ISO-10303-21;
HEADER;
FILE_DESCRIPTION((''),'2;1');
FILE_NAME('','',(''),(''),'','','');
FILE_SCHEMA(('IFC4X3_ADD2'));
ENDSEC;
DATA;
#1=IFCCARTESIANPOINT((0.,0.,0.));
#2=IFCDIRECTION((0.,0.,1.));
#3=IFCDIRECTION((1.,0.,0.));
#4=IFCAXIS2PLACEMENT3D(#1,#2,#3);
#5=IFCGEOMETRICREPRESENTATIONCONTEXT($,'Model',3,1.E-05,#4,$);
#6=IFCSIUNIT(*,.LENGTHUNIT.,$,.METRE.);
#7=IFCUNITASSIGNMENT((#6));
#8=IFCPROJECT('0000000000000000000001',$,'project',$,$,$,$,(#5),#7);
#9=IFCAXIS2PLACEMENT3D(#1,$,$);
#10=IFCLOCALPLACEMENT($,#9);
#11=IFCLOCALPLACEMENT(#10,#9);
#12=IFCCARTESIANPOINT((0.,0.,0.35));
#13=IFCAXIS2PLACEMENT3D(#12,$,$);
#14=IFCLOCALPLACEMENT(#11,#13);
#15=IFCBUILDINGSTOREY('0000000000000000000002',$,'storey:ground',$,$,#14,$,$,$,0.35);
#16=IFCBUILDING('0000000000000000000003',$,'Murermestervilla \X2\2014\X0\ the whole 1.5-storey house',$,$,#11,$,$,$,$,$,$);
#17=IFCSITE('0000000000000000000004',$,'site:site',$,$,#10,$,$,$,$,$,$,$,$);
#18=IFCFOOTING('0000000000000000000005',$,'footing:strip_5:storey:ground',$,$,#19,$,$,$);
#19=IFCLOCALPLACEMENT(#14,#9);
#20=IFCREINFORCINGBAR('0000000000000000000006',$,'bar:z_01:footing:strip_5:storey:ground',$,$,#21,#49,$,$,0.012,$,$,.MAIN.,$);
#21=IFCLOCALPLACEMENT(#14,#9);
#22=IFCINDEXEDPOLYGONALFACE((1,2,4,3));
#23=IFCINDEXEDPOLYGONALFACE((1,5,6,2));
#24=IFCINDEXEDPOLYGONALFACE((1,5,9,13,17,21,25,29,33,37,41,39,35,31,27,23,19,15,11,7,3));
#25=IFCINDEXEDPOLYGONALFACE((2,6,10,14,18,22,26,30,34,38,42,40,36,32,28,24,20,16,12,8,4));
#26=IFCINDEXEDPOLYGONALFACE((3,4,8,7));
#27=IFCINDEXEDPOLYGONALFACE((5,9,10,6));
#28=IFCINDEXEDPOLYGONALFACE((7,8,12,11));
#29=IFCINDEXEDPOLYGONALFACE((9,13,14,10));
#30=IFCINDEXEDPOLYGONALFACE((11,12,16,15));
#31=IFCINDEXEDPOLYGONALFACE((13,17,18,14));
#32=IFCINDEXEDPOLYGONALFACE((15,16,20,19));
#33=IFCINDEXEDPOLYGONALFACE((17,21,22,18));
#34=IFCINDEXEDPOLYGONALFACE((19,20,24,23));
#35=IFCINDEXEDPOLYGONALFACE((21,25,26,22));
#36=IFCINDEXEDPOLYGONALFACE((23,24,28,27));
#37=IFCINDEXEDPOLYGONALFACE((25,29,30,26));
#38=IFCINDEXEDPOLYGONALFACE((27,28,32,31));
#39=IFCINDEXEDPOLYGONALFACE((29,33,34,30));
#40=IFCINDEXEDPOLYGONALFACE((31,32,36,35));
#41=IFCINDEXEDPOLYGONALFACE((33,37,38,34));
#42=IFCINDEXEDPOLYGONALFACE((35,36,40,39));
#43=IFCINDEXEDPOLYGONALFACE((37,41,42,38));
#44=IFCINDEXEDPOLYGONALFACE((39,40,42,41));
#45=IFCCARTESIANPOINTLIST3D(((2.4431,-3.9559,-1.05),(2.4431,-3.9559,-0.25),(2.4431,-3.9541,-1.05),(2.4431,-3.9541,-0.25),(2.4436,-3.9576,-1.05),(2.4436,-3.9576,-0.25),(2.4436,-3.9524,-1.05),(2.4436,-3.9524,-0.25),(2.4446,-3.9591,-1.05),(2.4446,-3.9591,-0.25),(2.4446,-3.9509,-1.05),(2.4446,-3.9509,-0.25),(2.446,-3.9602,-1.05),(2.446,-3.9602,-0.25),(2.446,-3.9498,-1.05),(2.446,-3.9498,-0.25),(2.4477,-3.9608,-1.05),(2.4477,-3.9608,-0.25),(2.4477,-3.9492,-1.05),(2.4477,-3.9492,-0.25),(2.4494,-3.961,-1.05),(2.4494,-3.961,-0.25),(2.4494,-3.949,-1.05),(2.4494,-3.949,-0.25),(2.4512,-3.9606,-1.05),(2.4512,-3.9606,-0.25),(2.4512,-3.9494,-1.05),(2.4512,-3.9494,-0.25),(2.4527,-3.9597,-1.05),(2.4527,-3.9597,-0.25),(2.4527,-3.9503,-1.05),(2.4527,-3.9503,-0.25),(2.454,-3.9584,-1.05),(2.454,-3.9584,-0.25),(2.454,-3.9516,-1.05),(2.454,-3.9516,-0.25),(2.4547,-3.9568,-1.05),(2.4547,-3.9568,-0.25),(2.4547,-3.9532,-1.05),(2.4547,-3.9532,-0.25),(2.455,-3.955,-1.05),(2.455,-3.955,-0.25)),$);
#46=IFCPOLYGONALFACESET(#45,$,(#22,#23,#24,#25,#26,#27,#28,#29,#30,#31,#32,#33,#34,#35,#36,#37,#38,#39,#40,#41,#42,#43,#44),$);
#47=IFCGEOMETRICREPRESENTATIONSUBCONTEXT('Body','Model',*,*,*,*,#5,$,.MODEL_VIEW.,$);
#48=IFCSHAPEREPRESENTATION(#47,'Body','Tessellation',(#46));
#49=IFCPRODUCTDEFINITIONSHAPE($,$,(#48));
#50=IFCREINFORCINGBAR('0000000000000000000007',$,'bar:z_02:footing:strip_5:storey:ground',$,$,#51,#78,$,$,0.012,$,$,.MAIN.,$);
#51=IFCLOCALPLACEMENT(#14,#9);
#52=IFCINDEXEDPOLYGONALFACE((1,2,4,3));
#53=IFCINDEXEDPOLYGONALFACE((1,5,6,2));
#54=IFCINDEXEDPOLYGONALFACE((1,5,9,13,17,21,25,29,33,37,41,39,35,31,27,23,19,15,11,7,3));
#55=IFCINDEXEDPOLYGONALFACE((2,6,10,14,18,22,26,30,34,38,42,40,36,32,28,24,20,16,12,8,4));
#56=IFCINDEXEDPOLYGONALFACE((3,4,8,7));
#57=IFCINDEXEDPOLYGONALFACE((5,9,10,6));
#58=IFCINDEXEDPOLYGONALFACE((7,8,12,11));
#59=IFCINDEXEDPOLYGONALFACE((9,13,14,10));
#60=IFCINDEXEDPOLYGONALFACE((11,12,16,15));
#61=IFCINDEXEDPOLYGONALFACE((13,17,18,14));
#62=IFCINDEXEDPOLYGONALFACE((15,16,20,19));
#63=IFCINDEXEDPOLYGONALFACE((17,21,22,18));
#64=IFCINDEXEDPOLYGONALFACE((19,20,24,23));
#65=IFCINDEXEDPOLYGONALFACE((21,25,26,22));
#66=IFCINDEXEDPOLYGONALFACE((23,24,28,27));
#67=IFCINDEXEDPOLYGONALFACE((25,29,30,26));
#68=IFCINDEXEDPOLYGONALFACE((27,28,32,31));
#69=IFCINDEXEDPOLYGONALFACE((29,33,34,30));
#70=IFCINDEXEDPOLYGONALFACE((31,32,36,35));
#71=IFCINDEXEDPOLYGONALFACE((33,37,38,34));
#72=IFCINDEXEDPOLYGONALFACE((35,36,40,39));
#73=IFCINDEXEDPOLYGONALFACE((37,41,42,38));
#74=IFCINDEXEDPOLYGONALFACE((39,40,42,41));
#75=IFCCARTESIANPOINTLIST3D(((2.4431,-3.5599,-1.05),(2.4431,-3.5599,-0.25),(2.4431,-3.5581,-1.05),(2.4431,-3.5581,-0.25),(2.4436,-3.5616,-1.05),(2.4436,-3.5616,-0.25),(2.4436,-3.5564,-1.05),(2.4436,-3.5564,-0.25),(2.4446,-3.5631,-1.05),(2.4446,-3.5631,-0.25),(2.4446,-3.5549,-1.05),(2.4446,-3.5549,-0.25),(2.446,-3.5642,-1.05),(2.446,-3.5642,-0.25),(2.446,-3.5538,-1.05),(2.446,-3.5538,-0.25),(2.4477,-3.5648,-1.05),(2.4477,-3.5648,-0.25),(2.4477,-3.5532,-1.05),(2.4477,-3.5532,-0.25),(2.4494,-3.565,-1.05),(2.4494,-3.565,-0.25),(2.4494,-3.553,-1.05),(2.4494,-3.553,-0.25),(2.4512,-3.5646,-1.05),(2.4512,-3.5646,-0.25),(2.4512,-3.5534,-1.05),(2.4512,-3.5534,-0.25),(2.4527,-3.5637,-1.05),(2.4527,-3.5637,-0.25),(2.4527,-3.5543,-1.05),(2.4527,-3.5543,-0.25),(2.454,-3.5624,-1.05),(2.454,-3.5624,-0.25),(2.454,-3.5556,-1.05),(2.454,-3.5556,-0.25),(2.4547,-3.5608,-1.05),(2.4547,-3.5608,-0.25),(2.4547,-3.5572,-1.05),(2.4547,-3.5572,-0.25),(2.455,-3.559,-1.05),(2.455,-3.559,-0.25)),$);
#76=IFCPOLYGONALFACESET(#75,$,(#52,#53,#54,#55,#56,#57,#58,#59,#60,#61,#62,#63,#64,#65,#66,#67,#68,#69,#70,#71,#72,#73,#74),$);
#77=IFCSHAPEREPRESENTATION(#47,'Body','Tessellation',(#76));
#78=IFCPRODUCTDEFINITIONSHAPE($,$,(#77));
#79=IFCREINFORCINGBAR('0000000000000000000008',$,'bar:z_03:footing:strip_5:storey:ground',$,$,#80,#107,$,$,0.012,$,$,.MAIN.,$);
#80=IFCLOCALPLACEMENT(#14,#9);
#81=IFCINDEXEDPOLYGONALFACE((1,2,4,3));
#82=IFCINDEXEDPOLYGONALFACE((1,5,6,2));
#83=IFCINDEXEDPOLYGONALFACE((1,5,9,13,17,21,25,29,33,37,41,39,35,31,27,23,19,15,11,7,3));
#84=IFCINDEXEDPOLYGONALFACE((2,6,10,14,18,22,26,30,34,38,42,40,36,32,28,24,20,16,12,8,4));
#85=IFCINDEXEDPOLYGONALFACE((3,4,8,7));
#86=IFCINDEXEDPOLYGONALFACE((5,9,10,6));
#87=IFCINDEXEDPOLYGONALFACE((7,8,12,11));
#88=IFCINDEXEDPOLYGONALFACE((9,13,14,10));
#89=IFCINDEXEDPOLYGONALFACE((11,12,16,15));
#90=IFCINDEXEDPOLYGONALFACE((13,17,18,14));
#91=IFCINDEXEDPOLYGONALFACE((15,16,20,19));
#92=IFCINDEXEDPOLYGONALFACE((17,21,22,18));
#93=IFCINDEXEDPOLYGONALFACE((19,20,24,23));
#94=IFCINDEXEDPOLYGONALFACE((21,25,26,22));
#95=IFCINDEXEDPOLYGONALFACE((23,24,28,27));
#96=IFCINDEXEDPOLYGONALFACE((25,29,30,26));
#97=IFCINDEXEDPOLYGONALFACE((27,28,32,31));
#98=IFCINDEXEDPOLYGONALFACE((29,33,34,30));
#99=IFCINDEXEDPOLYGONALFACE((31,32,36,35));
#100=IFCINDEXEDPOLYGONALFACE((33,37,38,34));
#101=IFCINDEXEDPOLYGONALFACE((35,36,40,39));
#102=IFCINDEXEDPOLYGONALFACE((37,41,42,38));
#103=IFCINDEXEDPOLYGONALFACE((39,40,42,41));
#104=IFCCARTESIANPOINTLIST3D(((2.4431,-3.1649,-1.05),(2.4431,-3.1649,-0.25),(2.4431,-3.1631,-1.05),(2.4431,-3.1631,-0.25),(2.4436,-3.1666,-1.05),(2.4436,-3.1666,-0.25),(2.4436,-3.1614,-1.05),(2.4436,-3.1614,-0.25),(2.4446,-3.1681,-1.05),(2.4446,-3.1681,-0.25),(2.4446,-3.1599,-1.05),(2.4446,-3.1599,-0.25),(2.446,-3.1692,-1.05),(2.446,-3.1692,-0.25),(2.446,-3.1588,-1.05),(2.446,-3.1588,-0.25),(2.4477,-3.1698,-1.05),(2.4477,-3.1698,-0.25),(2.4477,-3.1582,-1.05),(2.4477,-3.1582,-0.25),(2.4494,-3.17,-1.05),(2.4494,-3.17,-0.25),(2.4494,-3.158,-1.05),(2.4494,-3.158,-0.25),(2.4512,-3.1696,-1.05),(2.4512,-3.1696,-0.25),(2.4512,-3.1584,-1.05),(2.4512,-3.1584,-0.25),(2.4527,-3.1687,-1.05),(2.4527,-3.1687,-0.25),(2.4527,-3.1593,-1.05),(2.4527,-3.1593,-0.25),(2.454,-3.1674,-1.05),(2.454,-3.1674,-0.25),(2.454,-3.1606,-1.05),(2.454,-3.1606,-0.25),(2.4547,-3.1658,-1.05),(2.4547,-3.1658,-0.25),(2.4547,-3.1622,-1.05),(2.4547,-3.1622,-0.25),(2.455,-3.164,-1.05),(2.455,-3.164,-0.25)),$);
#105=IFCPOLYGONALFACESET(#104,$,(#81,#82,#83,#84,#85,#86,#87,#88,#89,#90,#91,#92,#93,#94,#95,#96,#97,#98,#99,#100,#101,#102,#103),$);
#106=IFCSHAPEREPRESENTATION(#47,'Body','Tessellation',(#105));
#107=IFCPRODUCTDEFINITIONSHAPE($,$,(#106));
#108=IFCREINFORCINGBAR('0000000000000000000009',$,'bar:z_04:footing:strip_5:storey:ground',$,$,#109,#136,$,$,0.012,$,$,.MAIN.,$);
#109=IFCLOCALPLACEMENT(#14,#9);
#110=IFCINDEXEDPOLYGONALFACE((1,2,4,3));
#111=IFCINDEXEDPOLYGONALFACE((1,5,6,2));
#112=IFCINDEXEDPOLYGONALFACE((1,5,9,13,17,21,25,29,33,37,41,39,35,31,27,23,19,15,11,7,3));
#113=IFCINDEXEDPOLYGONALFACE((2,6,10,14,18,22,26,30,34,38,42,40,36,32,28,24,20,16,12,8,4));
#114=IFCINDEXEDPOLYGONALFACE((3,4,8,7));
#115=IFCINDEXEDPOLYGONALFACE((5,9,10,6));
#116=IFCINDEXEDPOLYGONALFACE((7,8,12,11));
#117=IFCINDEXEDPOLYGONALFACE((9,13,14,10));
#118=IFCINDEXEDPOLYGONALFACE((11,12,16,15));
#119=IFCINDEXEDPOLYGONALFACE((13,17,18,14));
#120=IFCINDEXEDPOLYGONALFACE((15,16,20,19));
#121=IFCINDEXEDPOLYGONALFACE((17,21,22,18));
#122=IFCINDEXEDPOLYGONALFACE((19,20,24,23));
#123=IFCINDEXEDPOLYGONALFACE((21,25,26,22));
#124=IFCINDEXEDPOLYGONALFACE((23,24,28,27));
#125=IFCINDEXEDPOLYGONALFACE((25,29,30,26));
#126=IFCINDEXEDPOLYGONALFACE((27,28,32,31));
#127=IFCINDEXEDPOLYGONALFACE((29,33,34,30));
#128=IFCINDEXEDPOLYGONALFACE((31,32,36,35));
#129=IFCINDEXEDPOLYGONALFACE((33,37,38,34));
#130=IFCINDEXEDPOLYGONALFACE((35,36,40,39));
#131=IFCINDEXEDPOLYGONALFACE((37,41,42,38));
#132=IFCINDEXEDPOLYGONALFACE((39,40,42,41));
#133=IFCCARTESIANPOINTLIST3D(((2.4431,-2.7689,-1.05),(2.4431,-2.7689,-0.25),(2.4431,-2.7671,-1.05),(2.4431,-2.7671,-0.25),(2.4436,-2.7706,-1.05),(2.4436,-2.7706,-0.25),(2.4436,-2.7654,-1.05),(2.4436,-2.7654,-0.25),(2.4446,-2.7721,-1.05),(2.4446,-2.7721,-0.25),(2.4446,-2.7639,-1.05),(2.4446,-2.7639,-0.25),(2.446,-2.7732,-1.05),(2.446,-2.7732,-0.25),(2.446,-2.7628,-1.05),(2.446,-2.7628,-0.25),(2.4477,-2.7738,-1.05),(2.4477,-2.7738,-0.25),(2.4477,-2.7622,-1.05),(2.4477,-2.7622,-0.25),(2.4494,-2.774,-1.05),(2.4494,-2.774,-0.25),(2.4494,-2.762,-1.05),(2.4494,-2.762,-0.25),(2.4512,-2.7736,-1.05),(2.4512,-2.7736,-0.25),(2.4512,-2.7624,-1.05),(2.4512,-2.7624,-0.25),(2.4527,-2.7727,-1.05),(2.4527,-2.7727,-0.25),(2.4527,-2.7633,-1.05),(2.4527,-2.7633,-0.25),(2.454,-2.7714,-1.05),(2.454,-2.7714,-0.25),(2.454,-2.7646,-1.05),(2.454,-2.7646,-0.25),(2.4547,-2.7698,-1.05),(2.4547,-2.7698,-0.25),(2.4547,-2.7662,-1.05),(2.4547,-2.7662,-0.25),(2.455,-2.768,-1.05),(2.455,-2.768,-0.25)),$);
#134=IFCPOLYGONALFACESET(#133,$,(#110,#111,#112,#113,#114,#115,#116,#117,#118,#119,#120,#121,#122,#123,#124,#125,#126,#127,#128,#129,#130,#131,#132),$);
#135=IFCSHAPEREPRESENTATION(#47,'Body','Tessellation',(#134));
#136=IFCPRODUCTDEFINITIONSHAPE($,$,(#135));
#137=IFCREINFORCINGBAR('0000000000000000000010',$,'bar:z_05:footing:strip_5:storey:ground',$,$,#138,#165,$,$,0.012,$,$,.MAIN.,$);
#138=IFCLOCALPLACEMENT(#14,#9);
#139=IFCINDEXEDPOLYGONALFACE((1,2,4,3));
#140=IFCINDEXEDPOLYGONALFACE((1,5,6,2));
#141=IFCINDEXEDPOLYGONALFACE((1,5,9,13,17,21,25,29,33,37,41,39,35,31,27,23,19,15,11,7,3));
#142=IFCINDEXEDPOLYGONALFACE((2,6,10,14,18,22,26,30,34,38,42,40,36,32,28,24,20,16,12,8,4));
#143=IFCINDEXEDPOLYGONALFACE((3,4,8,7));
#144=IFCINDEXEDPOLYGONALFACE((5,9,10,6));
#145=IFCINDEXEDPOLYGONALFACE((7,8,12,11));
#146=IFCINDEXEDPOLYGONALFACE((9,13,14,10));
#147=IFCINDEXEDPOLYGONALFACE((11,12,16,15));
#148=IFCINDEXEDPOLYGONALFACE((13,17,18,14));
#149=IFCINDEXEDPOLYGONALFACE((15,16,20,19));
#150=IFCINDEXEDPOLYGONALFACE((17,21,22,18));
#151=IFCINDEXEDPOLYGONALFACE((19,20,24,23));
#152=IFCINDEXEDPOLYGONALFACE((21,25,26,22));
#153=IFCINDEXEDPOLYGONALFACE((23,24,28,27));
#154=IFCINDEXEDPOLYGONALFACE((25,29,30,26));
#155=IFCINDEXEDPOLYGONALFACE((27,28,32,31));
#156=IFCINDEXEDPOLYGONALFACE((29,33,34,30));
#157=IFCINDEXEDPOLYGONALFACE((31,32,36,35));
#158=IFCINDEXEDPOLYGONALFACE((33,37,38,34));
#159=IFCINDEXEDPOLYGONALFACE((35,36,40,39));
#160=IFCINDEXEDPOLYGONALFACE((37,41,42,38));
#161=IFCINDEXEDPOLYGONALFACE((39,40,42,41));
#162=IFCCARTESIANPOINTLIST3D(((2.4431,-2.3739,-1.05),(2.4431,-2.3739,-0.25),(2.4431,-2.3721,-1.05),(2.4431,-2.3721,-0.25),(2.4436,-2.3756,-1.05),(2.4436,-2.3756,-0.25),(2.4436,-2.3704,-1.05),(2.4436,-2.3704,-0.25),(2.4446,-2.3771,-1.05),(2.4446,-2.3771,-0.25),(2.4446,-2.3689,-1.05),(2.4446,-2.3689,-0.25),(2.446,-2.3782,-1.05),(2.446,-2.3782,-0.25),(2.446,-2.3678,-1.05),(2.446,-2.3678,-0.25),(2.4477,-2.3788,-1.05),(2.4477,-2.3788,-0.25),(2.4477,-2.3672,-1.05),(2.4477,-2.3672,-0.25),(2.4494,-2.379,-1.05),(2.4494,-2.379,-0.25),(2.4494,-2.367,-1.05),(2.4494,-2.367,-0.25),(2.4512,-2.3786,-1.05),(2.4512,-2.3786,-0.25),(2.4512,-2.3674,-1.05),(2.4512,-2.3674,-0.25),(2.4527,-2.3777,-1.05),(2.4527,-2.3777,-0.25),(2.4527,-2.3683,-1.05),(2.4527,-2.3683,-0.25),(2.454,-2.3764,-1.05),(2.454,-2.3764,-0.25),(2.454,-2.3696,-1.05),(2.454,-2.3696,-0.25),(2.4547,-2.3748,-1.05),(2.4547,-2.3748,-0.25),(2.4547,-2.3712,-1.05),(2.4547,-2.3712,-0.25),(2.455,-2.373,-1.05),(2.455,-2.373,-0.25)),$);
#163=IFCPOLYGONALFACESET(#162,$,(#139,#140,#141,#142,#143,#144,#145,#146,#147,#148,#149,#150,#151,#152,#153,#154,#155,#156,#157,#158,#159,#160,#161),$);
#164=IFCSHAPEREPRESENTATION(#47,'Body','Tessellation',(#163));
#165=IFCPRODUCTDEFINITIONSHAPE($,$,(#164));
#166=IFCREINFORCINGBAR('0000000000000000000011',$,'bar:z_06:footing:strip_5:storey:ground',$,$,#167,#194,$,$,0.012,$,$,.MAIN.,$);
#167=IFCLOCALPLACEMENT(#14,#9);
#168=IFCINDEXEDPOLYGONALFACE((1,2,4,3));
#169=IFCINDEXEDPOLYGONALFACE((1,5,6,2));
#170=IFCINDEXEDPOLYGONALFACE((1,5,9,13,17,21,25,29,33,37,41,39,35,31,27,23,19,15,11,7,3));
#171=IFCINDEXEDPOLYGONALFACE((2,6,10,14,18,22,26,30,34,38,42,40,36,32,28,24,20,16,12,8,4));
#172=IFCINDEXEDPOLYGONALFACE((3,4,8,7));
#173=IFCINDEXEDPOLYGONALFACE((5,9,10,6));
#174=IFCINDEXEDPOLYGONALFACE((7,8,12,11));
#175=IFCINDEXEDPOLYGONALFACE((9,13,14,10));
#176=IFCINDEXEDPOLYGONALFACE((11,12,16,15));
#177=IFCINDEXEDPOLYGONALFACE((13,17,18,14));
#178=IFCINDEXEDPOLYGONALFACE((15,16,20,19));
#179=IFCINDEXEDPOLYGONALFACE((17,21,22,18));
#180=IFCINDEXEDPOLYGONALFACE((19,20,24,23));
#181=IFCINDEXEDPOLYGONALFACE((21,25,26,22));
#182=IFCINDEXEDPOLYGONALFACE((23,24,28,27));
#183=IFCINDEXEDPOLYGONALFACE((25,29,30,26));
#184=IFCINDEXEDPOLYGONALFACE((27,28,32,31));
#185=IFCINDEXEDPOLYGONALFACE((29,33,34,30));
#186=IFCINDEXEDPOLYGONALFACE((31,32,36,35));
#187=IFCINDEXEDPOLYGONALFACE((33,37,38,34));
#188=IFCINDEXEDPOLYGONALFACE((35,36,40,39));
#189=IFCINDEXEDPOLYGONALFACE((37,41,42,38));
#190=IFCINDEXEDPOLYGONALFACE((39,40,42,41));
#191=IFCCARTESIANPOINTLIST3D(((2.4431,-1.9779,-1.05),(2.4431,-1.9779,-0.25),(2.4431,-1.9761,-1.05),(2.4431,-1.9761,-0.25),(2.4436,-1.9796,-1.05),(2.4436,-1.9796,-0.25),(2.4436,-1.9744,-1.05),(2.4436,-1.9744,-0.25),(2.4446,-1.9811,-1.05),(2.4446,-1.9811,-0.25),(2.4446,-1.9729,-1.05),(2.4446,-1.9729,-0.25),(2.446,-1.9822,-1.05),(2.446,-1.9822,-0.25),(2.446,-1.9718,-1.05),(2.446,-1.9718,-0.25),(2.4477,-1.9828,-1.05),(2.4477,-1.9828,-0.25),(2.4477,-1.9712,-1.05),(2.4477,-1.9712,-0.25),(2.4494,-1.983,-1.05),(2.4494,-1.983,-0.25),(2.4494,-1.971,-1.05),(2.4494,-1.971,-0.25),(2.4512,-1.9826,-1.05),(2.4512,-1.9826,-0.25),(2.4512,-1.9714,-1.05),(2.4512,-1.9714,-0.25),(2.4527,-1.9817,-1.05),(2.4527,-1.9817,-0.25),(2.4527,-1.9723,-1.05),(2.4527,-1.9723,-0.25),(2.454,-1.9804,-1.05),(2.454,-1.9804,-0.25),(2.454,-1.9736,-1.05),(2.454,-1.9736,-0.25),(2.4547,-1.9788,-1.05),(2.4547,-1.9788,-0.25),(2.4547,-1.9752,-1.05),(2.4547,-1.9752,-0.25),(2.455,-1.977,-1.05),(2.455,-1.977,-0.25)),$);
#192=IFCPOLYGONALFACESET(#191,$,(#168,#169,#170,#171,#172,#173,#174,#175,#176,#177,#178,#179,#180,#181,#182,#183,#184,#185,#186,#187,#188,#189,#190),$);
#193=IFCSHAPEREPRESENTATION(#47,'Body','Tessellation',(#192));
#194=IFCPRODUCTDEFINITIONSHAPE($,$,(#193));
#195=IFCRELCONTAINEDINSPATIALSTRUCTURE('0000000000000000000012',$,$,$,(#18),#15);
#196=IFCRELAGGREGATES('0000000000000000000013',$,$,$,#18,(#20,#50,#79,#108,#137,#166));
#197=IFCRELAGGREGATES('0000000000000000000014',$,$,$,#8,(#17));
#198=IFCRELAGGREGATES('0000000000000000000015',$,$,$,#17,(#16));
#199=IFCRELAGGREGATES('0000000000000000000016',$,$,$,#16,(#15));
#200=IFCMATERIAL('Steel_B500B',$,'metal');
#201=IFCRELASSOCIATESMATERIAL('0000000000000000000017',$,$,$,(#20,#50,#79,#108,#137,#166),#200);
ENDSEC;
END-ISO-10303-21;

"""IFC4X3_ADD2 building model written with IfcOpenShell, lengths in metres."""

from ifc_helpers import new_model, entity, si_unit, frame, origin, origin_with_axes, place, context, subcontext, project, spatial, material, element, aggregate, save


model = new_model("IFC4X3_ADD2")

# Units and contexts
model_context = context("Model", 3, precision=1e-05, world=origin_with_axes())
body_context = subcontext(model_context, "Body", "Model", "MODEL_VIEW")
ifc_project = project(units=[si_unit("LENGTHUNIT", "METRE")], contexts=[model_context])

# Site, building, storey
placement_1 = place(None, origin())
site = spatial("IfcSite", under=ifc_project, at=placement_1, Name="site:site")
building_placement = place(placement_1, origin())
building = spatial("IfcBuilding", under=site, at=building_placement, Name="Murermestervilla — the whole 1.5-storey house")
storey_placement = place(building_placement, frame((0.0, 0.0, 0.35)))
storey = spatial("IfcBuildingStorey", under=building, at=storey_placement, Name="storey:ground", Elevation=0.35)

# Footing, reinforcing bars
placement_2 = place(storey_placement, frame((0.0, 0.0, -0.35)))
ifc_material = material(Name="Steel_B500B", Category="metal")
footing_1 = element("IfcFooting", 1, at=placement_2, inside=storey, Name="footing:strip_5:storey:ground")
reinforcing_bar_1 = element("IfcReinforcingBar", 2, at=placement_1, material=ifc_material, Name="bar:z_01:footing:strip_5:storey:ground", NominalDiameter=0.012, PredefinedType="MAIN", context=body_context, shape_type="AdvancedSweptSolid", body=[
    entity("IfcSweptDiskSolid", entity("IfcPolyline", [entity("IfcCartesianPoint", [2.449, -3.955, -0.7]), entity("IfcCartesianPoint", [2.449, -3.955, 0.1])]), 0.006),
])
reinforcing_bar_2 = element("IfcReinforcingBar", 3, at=placement_1, material=ifc_material, Name="bar:z_02:footing:strip_5:storey:ground", NominalDiameter=0.012, PredefinedType="MAIN", context=body_context, shape_type="AdvancedSweptSolid", body=[
    entity("IfcSweptDiskSolid", entity("IfcPolyline", [entity("IfcCartesianPoint", [2.449, -3.559, -0.7]), entity("IfcCartesianPoint", [2.449, -3.559, 0.1])]), 0.006),
])
reinforcing_bar_3 = element("IfcReinforcingBar", 4, at=placement_1, material=ifc_material, Name="bar:z_03:footing:strip_5:storey:ground", NominalDiameter=0.012, PredefinedType="MAIN", context=body_context, shape_type="AdvancedSweptSolid", body=[
    entity("IfcSweptDiskSolid", entity("IfcPolyline", [entity("IfcCartesianPoint", [2.449, -3.164, -0.7]), entity("IfcCartesianPoint", [2.449, -3.164, 0.1])]), 0.006),
])
reinforcing_bar_4 = element("IfcReinforcingBar", 5, at=placement_1, material=ifc_material, Name="bar:z_04:footing:strip_5:storey:ground", NominalDiameter=0.012, PredefinedType="MAIN", context=body_context, shape_type="AdvancedSweptSolid", body=[
    entity("IfcSweptDiskSolid", entity("IfcPolyline", [entity("IfcCartesianPoint", [2.449, -2.768, -0.7]), entity("IfcCartesianPoint", [2.449, -2.768, 0.1])]), 0.006),
])
reinforcing_bar_5 = element("IfcReinforcingBar", 6, at=placement_1, material=ifc_material, Name="bar:z_05:footing:strip_5:storey:ground", NominalDiameter=0.012, PredefinedType="MAIN", context=body_context, shape_type="AdvancedSweptSolid", body=[
    entity("IfcSweptDiskSolid", entity("IfcPolyline", [entity("IfcCartesianPoint", [2.449, -2.373, -0.7]), entity("IfcCartesianPoint", [2.449, -2.373, 0.1])]), 0.006),
])
reinforcing_bar_6 = element("IfcReinforcingBar", 7, at=placement_1, material=ifc_material, Name="bar:z_06:footing:strip_5:storey:ground", NominalDiameter=0.012, PredefinedType="MAIN", context=body_context, shape_type="AdvancedSweptSolid", body=[
    entity("IfcSweptDiskSolid", entity("IfcPolyline", [entity("IfcCartesianPoint", [2.449, -1.977, -0.7]), entity("IfcCartesianPoint", [2.449, -1.977, 0.1])]), 0.006),
])
aggregate(footing_1, [reinforcing_bar_1, reinforcing_bar_2, reinforcing_bar_3, reinforcing_bar_4, reinforcing_bar_5, reinforcing_bar_6])

save(model, "model.ifc")
